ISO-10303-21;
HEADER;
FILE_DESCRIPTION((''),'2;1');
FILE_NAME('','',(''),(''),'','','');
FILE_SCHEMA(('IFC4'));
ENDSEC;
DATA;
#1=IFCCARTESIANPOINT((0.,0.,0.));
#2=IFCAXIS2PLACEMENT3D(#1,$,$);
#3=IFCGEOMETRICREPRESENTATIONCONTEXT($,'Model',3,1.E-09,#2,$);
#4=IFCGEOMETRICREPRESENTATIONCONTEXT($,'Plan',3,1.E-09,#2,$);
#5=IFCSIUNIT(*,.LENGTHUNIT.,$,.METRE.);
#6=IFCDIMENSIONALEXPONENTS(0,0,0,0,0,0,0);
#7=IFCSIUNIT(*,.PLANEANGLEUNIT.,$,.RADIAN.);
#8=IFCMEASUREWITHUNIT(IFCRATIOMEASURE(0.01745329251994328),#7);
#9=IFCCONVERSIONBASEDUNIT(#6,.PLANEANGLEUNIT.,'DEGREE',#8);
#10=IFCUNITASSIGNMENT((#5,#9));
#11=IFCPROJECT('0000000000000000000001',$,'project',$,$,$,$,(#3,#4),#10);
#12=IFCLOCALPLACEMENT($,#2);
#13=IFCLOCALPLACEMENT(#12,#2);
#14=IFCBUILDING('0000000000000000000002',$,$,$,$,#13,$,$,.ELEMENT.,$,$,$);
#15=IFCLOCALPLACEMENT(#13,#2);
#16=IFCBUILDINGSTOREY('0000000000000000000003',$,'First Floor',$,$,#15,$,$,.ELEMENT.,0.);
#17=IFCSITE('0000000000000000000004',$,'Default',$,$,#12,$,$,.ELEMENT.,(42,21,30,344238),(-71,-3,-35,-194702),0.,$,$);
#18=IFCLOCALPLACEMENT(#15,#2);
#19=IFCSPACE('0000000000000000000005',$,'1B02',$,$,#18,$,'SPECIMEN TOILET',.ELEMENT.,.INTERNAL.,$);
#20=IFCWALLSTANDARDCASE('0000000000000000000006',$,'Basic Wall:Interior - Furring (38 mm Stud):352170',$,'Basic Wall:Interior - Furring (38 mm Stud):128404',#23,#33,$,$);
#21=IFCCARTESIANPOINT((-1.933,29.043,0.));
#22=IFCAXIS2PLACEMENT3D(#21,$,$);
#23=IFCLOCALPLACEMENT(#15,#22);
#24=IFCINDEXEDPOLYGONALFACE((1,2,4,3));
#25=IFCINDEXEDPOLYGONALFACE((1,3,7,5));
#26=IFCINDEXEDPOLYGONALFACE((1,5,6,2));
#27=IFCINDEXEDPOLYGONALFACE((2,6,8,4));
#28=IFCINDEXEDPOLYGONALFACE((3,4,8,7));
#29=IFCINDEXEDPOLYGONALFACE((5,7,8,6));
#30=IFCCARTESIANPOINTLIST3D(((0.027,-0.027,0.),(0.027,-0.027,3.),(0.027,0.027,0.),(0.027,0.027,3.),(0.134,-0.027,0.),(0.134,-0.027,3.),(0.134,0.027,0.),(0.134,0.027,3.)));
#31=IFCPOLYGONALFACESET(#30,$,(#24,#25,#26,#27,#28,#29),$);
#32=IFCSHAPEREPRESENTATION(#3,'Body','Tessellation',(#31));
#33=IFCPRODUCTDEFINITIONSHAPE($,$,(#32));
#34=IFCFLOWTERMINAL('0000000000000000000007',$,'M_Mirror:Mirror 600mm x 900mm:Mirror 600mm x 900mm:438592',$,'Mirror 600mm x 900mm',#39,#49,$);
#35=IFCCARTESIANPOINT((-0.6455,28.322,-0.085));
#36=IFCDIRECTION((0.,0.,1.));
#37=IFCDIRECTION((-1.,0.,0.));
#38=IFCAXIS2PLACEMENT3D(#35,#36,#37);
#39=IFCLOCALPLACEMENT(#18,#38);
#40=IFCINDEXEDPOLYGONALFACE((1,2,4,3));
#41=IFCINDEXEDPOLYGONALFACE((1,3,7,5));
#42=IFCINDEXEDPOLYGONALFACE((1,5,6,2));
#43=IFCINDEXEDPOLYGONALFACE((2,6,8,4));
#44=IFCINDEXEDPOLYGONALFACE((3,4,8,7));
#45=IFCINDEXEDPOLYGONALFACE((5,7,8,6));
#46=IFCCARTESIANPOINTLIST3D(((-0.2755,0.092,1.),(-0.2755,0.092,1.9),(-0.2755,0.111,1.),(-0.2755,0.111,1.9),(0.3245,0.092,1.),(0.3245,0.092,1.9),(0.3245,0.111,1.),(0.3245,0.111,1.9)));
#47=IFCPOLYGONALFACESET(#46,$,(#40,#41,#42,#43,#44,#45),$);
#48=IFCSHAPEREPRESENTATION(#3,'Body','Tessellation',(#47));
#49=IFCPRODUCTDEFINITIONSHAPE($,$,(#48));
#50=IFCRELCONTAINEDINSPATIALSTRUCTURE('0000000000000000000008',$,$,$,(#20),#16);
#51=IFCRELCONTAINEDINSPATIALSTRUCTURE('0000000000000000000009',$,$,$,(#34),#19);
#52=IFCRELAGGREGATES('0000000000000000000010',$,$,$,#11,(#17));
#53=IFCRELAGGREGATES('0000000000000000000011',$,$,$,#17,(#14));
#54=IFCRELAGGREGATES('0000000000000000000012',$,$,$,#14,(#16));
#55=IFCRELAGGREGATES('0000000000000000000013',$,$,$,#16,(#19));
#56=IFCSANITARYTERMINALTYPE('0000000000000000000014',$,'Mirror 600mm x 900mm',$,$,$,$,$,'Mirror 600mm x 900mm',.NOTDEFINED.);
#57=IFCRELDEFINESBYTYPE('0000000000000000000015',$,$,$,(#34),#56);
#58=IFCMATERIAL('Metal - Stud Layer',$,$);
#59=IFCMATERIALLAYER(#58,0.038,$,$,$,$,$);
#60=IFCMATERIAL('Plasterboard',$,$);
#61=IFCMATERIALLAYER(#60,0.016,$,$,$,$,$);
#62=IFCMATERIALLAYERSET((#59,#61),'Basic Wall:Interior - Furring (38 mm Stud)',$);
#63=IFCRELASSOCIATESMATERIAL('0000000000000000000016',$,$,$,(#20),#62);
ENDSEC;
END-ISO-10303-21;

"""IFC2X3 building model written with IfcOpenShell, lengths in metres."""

from ifc_helpers import new_model, entity, si_unit, converted_unit, frame, frame_2d, origin, origin_2d_with_axis, place, context, project, spatial, rectangle, extrude, source, transform, mapped, material, layer, layer_set, layer_usage, type_object, type_shapes, element, save


model = new_model("IFC2X3")

# Units and contexts
model_context = context("Model", 3, precision=1e-09, world=origin())
plan_context = context("Plan", 3, precision=1e-09, world=origin())
ifc_project = project(units=[si_unit("LENGTHUNIT", "METRE"), converted_unit("PLANEANGLEUNIT", "DEGREE", entity("IfcRatioMeasure", 0.01745329251994328), si_unit("PLANEANGLEUNIT", "RADIAN"), dimensions=[0, 0, 0, 0, 0, 0, 0])], contexts=[model_context, plan_context])

# Site, building, storey
site_placement = place(None, origin())
site = spatial("IfcSite", under=ifc_project, at=site_placement, Name="Default", CompositionType="ELEMENT", RefLatitude=(42, 21, 30, 344238), RefLongitude=(-71, -3, -35, -194702), RefElevation=0.0)
building_placement = place(site_placement, origin())
building = spatial("IfcBuilding", under=site, at=building_placement, CompositionType="ELEMENT")
storey_placement = place(building_placement, origin())
storey = spatial("IfcBuildingStorey", under=building, at=storey_placement, Name="First Floor", CompositionType="ELEMENT", Elevation=0.0)

# Shared definitions
ifc_material_1 = material(Name="Plasterboard")
ifc_layer_1 = layer(ifc_material_1, 0.016)
ifc_material_2 = material(Name="Metal - Stud Layer")

# Wall
ifc_layer_2 = layer(ifc_material_2, 0.038)
ifc_layer_set_1 = layer_set([ifc_layer_2, ifc_layer_1], Name="Basic Wall:Interior - Furring (38 mm Stud)")
ifc_layer_usage_1 = layer_usage(ifc_layer_set_1, "AXIS2", "POSITIVE", -0.027)
wall_1_placement = place(storey_placement, frame((-1.933, 29.043, 0.0)))
element("IfcWallStandardCase", 1, at=wall_1_placement, inside=storey, material=ifc_layer_usage_1, Name="Basic Wall:Interior - Furring (38 mm Stud):352170", ObjectType="Basic Wall:Interior - Furring (38 mm Stud):128404", context=model_context, shape_type="SweptSolid", body=[
    extrude(rectangle(XDim=0.107, YDim=0.054, at=frame_2d((0.0805, 0.0), x_axis=(-1.0, 0.0))), origin(), (0.0, 0.0, 1.0), 3.0),
])

# Shared definitions
space_1_placement = place(storey_placement, origin())
space_1 = spatial("IfcSpace", under=storey, at=space_1_placement, Name="1B02", LongName="SPECIMEN TOILET", CompositionType="ELEMENT", InteriorOrExteriorSpace="INTERNAL")

# Flow terminal
sanitary_terminal_type = type_object("IfcSanitaryTerminalType", Name="Mirror 600mm x 900mm", ElementType="Mirror 600mm x 900mm", PredefinedType="NOTDEFINED")
shared_shape_1 = source(origin(), model_context, "Body", "SweptSolid", [
    extrude(rectangle(XDim=0.0191, YDim=0.6, at=origin_2d_with_axis()), frame((0.0245, 0.1015, 1.0), z_axis=(0.0, 0.0, 1.0), x_axis=(0.0, -1.0, 0.0)), (0.0, 0.0, 1.0), 0.9),
])
type_shapes(sanitary_terminal_type, [shared_shape_1])
flow_terminal_placement = place(space_1_placement, frame((-0.6455, 28.322, -0.085), z_axis=(0.0, 0.0, 1.0), x_axis=(-1.0, 0.0, 0.0)))
element("IfcFlowTerminal", 2, at=flow_terminal_placement, inside=space_1, type_object=sanitary_terminal_type, Name="M_Mirror:Mirror 600mm x 900mm:Mirror 600mm x 900mm:438592", ObjectType="Mirror 600mm x 900mm", context=model_context, shape_type="MappedRepresentation", body=[
    mapped(shared_shape_1, transform((0.0, 0.0, 0.0), scale=1.0)),
])

save(model, "model.ifc")
